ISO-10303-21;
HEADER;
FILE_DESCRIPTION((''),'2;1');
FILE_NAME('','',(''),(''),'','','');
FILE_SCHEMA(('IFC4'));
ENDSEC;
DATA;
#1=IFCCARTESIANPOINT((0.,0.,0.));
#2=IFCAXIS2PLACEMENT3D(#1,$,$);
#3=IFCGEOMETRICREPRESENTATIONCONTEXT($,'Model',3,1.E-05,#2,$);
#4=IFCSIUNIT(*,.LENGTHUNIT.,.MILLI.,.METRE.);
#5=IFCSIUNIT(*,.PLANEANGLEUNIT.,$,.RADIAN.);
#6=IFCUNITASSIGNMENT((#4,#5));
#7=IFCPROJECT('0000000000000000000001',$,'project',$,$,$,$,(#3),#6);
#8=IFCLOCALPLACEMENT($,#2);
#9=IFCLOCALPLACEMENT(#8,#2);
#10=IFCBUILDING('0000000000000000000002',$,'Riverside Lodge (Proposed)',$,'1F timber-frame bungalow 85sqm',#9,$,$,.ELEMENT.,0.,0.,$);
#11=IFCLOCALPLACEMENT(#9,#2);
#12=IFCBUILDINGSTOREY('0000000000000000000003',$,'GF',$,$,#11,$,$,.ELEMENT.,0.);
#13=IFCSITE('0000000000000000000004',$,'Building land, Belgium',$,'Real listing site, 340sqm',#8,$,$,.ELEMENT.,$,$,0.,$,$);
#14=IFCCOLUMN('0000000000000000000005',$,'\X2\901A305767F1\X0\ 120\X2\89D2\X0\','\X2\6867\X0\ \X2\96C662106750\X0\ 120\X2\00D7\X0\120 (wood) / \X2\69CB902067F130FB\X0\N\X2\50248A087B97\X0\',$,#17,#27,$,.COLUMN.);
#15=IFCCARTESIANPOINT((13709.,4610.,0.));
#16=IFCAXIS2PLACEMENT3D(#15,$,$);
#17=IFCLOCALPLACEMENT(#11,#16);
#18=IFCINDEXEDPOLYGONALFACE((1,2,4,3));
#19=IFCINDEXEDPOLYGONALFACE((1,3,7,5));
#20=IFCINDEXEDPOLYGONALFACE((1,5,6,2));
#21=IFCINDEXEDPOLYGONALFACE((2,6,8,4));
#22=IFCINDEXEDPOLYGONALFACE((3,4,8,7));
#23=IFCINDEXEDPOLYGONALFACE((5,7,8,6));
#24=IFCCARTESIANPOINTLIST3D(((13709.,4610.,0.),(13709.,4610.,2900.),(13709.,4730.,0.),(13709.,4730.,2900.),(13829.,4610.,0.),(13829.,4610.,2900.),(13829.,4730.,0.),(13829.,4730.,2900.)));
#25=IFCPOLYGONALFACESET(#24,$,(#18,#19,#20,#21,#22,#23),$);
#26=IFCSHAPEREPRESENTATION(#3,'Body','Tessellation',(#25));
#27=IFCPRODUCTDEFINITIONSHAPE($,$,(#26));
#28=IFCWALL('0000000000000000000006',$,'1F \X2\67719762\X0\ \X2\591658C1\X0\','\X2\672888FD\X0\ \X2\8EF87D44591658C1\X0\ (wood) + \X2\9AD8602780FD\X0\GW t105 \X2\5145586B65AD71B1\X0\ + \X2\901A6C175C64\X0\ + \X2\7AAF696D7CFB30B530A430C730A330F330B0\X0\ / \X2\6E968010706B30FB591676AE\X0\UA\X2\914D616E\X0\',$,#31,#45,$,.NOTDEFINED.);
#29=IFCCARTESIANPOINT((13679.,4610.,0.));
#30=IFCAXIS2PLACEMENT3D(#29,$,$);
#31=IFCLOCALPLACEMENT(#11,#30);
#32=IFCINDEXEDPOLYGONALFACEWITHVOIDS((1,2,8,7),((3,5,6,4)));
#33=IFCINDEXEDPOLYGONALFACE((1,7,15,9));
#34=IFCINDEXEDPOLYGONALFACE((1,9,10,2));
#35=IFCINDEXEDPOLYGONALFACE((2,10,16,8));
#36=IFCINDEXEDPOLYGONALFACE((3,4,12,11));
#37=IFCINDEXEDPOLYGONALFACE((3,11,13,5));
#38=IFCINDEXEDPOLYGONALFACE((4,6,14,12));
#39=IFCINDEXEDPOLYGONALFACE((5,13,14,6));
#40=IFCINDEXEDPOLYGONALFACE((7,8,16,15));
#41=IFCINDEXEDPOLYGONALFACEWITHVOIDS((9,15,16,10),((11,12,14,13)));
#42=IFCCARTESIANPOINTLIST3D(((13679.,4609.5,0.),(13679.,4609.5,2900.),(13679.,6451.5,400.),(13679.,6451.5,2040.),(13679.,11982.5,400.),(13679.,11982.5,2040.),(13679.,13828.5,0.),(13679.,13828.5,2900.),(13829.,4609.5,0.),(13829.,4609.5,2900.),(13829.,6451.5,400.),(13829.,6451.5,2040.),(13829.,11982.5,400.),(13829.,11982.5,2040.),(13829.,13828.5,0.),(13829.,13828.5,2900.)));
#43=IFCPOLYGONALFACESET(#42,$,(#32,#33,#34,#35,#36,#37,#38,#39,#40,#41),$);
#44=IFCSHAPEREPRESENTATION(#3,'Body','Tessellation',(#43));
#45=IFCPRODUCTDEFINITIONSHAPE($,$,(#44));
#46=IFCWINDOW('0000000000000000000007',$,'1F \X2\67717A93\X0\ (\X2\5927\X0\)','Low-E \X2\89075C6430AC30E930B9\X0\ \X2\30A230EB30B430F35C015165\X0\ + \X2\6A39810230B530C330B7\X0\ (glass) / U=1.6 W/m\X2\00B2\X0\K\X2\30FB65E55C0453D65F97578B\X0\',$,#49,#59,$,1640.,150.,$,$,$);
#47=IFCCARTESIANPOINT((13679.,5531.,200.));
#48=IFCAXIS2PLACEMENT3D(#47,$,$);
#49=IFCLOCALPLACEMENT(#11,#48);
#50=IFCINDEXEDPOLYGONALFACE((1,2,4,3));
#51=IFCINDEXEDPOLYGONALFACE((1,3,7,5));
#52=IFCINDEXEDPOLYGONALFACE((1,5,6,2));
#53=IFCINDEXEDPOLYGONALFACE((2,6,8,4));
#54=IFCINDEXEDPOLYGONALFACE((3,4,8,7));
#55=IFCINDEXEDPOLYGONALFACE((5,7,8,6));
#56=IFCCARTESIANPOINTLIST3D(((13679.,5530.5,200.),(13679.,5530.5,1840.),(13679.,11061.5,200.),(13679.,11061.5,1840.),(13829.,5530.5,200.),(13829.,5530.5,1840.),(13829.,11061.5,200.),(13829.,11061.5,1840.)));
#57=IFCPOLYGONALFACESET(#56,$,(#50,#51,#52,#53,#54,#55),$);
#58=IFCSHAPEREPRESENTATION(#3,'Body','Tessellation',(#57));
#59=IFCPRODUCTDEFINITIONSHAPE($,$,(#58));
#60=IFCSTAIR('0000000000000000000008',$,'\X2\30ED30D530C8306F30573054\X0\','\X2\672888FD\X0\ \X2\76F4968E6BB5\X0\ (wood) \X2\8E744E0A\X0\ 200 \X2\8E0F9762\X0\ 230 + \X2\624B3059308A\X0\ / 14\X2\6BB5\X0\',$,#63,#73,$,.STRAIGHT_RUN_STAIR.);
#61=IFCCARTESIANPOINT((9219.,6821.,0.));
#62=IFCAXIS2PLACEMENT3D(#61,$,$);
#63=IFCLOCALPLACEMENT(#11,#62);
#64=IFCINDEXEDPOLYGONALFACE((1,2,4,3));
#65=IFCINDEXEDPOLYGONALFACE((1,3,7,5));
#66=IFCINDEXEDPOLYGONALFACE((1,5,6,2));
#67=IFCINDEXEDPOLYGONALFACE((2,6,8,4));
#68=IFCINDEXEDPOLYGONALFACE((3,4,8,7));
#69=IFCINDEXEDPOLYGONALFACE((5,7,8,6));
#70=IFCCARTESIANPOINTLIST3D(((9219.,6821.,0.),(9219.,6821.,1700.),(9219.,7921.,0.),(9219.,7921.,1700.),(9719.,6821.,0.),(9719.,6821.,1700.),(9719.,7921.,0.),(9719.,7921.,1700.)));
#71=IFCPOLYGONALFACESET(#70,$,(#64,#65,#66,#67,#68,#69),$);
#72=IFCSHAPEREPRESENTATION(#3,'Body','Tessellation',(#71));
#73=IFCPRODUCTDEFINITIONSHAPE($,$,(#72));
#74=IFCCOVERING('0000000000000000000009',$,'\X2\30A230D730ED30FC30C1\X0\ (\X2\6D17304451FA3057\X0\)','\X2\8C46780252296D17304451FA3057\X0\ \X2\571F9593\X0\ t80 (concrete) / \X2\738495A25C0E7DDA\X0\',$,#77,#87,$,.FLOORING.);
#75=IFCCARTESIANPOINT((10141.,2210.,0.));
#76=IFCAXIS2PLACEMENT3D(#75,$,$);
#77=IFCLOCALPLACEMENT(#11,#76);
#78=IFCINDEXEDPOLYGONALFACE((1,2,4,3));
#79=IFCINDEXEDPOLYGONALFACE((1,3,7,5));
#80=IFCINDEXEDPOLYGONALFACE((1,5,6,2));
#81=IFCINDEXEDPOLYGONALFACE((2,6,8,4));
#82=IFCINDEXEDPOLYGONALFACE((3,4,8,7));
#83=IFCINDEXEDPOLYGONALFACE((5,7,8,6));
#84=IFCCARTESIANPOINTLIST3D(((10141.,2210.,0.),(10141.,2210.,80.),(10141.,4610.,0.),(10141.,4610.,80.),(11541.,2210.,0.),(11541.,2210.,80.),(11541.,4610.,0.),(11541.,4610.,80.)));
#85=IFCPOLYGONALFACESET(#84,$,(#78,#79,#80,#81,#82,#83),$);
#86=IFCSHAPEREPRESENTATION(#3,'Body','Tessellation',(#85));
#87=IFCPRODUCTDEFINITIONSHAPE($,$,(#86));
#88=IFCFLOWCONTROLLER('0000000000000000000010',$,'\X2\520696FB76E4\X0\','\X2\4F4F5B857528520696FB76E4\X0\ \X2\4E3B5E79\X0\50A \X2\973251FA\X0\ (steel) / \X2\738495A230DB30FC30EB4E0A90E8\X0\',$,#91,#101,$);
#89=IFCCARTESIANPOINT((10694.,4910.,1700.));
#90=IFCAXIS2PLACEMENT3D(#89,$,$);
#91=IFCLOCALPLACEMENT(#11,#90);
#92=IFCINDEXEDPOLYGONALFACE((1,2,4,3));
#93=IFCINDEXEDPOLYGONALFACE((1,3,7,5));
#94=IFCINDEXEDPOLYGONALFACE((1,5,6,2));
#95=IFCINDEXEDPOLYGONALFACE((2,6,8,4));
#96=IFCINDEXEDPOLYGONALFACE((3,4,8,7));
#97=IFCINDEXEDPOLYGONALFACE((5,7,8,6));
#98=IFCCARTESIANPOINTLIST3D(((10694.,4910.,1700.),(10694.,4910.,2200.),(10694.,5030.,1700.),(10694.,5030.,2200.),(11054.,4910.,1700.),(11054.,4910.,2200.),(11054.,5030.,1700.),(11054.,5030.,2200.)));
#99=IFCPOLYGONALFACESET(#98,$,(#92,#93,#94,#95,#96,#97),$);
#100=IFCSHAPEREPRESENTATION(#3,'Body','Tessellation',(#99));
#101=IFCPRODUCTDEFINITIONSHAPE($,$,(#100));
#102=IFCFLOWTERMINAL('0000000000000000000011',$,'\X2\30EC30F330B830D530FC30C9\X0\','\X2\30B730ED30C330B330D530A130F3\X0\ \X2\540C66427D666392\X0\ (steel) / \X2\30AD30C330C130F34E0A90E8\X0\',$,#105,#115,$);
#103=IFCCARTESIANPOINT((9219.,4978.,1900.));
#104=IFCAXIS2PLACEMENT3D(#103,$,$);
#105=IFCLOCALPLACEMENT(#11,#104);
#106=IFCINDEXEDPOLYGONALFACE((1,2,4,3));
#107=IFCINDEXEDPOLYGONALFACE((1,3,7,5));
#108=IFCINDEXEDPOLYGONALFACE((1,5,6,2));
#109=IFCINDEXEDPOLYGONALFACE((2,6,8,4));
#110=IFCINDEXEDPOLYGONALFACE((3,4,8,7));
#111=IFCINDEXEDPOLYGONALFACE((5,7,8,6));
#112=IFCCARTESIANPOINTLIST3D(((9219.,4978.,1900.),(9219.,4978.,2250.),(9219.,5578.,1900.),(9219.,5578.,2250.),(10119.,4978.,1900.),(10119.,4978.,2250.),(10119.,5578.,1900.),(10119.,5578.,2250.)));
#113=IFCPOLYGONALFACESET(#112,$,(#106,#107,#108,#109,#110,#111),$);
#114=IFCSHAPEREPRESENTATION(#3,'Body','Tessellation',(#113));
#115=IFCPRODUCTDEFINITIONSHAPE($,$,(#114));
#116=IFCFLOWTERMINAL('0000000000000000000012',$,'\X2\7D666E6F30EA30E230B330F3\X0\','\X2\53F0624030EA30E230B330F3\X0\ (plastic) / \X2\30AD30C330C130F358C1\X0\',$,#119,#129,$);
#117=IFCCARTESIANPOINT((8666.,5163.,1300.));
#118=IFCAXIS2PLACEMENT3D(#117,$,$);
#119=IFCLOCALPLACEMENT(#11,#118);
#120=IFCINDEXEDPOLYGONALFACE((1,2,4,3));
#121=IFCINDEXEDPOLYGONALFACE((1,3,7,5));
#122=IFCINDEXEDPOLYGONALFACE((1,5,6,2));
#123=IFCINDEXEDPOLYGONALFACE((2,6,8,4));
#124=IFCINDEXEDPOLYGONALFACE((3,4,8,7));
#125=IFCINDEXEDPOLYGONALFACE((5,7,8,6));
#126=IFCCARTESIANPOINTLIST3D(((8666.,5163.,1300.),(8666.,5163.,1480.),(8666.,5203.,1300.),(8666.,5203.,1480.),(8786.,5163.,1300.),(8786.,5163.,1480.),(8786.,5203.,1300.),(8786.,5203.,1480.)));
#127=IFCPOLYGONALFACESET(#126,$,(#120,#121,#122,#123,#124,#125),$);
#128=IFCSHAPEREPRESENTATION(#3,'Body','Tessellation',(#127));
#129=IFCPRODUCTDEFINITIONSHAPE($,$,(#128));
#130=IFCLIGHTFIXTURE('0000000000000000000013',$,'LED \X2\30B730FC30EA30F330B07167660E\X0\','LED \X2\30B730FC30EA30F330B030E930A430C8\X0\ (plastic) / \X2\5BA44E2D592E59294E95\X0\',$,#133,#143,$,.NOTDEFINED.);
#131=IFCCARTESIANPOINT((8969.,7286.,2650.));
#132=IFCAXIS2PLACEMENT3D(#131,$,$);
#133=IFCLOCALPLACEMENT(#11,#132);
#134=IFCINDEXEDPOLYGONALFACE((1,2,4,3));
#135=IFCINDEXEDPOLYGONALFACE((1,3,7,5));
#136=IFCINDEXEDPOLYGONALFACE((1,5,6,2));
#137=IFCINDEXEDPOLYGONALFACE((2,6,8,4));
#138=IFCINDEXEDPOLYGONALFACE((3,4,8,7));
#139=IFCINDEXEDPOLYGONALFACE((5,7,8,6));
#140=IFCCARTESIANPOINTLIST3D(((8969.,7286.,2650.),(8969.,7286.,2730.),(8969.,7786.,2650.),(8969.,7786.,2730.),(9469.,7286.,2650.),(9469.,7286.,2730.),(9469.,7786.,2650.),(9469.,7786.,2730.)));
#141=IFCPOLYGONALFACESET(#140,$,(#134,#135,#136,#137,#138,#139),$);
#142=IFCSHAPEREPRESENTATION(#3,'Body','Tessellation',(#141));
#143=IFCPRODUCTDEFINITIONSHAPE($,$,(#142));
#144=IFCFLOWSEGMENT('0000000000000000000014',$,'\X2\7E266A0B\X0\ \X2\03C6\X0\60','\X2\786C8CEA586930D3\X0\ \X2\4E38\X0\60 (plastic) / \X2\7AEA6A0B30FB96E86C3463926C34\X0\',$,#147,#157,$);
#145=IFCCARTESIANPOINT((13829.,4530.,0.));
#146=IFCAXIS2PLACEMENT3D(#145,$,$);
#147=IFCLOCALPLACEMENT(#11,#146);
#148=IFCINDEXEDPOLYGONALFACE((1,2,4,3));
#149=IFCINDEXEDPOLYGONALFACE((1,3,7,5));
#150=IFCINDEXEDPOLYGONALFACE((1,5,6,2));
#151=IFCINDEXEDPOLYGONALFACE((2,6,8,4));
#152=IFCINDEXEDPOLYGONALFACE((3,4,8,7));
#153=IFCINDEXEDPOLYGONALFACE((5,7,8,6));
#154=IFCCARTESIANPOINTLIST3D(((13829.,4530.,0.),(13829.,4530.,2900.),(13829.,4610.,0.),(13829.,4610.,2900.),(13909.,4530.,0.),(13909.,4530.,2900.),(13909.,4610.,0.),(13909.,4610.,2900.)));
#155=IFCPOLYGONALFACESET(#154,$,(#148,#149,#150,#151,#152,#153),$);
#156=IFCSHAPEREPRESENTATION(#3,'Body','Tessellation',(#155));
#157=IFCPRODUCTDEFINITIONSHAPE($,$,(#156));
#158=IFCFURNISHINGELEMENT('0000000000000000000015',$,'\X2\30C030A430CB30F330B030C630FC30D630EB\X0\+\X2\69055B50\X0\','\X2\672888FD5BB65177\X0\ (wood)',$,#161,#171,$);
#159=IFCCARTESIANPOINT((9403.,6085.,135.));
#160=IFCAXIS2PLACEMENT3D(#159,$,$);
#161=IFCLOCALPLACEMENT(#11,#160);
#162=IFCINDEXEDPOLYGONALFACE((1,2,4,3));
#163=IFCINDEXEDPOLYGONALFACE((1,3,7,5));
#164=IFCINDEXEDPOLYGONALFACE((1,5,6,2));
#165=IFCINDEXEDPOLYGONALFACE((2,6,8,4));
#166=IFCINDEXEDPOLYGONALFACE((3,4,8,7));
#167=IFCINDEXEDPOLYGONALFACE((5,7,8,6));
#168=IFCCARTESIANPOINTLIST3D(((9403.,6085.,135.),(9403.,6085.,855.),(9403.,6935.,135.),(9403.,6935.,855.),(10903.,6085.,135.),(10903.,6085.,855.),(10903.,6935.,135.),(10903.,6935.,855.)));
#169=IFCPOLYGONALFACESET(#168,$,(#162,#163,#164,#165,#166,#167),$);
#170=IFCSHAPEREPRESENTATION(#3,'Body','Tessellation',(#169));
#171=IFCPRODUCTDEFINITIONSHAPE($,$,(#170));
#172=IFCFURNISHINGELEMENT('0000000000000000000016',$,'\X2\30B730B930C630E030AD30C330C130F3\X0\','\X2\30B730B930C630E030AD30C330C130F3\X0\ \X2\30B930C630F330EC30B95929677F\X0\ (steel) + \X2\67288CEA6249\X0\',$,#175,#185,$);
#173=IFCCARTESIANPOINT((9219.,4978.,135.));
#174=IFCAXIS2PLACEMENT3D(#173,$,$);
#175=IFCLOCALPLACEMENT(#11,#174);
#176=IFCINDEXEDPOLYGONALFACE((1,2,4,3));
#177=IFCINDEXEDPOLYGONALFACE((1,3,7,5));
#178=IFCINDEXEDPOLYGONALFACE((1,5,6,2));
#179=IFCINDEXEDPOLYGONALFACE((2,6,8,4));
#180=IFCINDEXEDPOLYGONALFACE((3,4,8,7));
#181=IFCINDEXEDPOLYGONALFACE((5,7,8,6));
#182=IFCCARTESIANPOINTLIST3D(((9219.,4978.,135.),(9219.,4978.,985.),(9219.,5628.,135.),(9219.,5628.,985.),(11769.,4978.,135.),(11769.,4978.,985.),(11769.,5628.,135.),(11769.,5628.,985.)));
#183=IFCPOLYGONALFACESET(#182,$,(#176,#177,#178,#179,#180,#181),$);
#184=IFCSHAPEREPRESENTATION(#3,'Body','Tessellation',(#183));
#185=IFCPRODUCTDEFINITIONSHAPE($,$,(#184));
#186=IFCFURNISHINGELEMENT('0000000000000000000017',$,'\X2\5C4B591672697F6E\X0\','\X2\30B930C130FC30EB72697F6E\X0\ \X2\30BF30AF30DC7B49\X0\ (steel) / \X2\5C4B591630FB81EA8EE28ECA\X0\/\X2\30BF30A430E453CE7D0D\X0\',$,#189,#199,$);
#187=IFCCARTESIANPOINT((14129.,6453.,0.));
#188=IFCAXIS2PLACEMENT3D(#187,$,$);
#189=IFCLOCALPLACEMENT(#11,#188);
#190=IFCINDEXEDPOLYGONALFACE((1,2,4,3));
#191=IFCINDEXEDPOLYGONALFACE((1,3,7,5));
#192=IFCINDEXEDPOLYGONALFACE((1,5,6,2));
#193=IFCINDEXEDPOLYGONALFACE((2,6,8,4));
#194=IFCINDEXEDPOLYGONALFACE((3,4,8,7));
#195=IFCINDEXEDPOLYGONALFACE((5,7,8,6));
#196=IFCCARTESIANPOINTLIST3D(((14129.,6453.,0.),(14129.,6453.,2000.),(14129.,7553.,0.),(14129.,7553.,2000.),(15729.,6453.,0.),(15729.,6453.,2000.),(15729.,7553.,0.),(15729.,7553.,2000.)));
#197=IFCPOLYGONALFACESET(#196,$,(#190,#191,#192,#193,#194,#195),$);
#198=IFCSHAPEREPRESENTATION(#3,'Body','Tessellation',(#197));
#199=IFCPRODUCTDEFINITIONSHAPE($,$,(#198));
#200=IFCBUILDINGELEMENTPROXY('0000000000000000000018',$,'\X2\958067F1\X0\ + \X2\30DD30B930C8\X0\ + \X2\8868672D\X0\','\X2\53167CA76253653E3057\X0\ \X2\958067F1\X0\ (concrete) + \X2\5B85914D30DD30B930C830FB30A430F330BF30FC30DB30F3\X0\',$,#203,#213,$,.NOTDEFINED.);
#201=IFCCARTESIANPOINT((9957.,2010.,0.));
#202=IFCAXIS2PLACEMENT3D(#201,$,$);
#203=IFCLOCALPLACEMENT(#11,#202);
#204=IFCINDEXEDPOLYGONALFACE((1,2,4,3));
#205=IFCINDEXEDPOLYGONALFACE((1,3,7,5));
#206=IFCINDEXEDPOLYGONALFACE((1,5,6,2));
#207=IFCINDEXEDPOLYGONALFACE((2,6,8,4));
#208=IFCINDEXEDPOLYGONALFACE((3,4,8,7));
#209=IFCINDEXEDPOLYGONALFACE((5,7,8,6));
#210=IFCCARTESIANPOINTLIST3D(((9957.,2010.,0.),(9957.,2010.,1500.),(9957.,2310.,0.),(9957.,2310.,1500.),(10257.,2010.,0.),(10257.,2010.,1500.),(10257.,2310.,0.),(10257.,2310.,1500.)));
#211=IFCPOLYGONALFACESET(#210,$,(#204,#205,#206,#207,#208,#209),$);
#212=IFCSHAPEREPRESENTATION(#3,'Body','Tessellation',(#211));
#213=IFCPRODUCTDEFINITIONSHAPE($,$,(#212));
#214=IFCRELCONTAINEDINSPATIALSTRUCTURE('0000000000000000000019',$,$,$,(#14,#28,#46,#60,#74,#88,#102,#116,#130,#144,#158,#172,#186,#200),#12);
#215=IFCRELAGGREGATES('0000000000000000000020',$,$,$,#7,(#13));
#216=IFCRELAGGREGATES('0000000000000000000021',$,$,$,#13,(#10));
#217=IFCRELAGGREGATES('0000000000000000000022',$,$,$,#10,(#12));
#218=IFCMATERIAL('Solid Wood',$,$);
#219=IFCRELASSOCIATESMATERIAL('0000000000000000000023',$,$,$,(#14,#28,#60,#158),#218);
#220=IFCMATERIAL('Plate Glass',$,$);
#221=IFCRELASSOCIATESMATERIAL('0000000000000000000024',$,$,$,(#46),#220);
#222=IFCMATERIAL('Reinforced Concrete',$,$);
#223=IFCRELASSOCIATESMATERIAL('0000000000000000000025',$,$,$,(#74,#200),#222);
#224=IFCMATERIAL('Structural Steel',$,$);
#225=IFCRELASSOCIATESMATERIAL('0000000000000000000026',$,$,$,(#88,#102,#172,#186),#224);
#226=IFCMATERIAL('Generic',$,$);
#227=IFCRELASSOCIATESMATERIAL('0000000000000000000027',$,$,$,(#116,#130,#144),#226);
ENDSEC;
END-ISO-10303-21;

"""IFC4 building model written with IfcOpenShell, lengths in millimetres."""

from ifc_helpers import new_model, si_unit, frame, frame_2d, origin, place, context, project, spatial, rectangle, extrude, material, element, fill, save


model = new_model("IFC4")

# Units and contexts
model_context = context("Model", 3, precision=1e-05, world=origin())
ifc_project = project(units=[si_unit("LENGTHUNIT", "METRE", prefix="MILLI"), si_unit("PLANEANGLEUNIT", "RADIAN")], contexts=[model_context])

# Site, building, storey
site_placement = place(None, origin())
site = spatial("IfcSite", under=ifc_project, at=site_placement, Name="Building land, Belgium", ObjectType="Real listing site, 340sqm", CompositionType="ELEMENT", RefElevation=0.0)
building_placement = place(site_placement, origin())
building = spatial("IfcBuilding", under=site, at=building_placement, Name="Riverside Lodge (Proposed)", ObjectType="1F timber-frame bungalow 85sqm", CompositionType="ELEMENT", ElevationOfRefHeight=0.0, ElevationOfTerrain=0.0)
storey_placement = place(building_placement, origin())
storey = spatial("IfcBuildingStorey", under=building, at=storey_placement, Name="GF", CompositionType="ELEMENT", Elevation=0.0)

# Column
ifc_material_1 = material(Name="Solid Wood")
column_1_placement = place(storey_placement, frame((13709.0, 4610.0, 0.0)))
element("IfcColumn", 1, at=column_1_placement, inside=storey, material=ifc_material_1, Name="通し柱 120角", Description="桧 集成材 120×120 (wood) / 構造柱・N値計算", PredefinedType="COLUMN", context=model_context, shape_type="SweptSolid", body=[
    extrude(rectangle(XDim=120.0, YDim=120.0, at=frame_2d((60.0, 60.0))), frame((13709.0, 4610.0, 0.0)), (0.0, 0.0, 1.0), 2900.0),
])

# Wall, opening, window
wall_1_placement = place(storey_placement, frame((13679.0, 4610.0, 0.0)))
wall_1 = element("IfcWall", 2, at=wall_1_placement, inside=storey, material=ifc_material_1, Name="1F 東面 外壁", Description="木製 軸組外壁 (wood) + 高性能GW t105 充填断熱 + 通気層 + 窯業系サイディング / 準耐火・外皮UA配慮", PredefinedType="NOTDEFINED", context=model_context, shape_type="SweptSolid", body=[
    extrude(rectangle(XDim=150.0, YDim=9219.0, at=frame_2d((75.0, 4609.0))), frame((13679.0, 4610.0, 0.0)), (0.0, 0.0, 1.0), 2900.0),
])
opening_placement = place(storey_placement, frame((13679.0, 5531.0, 200.0)))
opening = element("IfcOpeningElement", 3, at=opening_placement, cuts=wall_1, PredefinedType="NOTDEFINED", context=model_context, shape_type="SweptSolid", body=[
    extrude(rectangle(XDim=150.0, YDim=5531.0, at=frame_2d((75.0, 2765.0))), frame((13679.0, 5531.0, 200.0)), (0.0, 0.0, 1.0), 1640.0),
])
ifc_material_2 = material(Name="Plate Glass")
window_placement = place(storey_placement, frame((13679.0, 5531.0, 200.0)))
window = element("IfcWindow", 4, at=window_placement, inside=storey, material=ifc_material_2, Name="1F 東窓 (大)", Description="Low-E 複層ガラス アルゴン封入 + 樹脂サッシ (glass) / U=1.6 W/m²K・日射取得型", OverallHeight=1640.0, OverallWidth=150.0, context=model_context, shape_type="SweptSolid", body=[
    extrude(rectangle(XDim=150.0, YDim=5531.0, at=frame_2d((75.0, 2765.0))), frame((13679.0, 5531.0, 200.0)), (0.0, 0.0, 1.0), 1640.0),
])
fill(opening, window)

# Stair
stair_placement = place(storey_placement, frame((9219.0, 6821.0, 0.0)))
element("IfcStair", 5, at=stair_placement, inside=storey, material=ifc_material_1, Name="ロフトはしご", Description="木製 直階段 (wood) 蹴上 200 踏面 230 + 手すり / 14段", PredefinedType="STRAIGHT_RUN_STAIR", context=model_context, shape_type="SweptSolid", body=[
    extrude(rectangle(XDim=500.0, YDim=1100.0, at=frame_2d((250.0, 550.0))), frame((9219.0, 6821.0, 0.0)), (0.0, 0.0, 1.0), 1700.0),
])

# Covering
ifc_material_3 = material(Name="Reinforced Concrete")
covering_placement = place(storey_placement, frame((10141.0, 2210.0, 0.0)))
element("IfcCovering", 6, at=covering_placement, inside=storey, material=ifc_material_3, Name="アプローチ (洗い出し)", Description="豆砂利洗い出し 土間 t80 (concrete) / 玄関導線", PredefinedType="FLOORING", context=model_context, shape_type="SweptSolid", body=[
    extrude(rectangle(XDim=1400.0, YDim=2400.0, at=frame_2d((700.0, 1200.0))), frame((10141.0, 2210.0, 0.0)), (0.0, 0.0, 1.0), 80.0),
])

# Flow controller
ifc_material_4 = material(Name="Structural Steel")
flow_controller_placement = place(storey_placement, frame((10694.0, 4910.0, 1700.0)))
element("IfcFlowController", 7, at=flow_controller_placement, inside=storey, material=ifc_material_4, Name="分電盤", Description="住宅用分電盤 主幹50A 露出 (steel) / 玄関ホール上部", context=model_context, shape_type="SweptSolid", body=[
    extrude(rectangle(XDim=360.0, YDim=120.0, at=frame_2d((180.0, 60.0))), frame((10694.0, 4910.0, 1700.0)), (0.0, 0.0, 1.0), 500.0),
])

# Flow terminals
flow_terminal_1_placement = place(storey_placement, frame((9219.0, 4978.0, 1900.0)))
element("IfcFlowTerminal", 8, at=flow_terminal_1_placement, inside=storey, material=ifc_material_4, Name="レンジフード", Description="シロッコファン 同時給排 (steel) / キッチン上部", context=model_context, shape_type="SweptSolid", body=[
    extrude(rectangle(XDim=900.0, YDim=600.0, at=frame_2d((450.0, 300.0))), frame((9219.0, 4978.0, 1900.0)), (0.0, 0.0, 1.0), 350.0),
])
ifc_material_5 = material(Name="Generic")
flow_terminal_2_placement = place(storey_placement, frame((8666.0, 5163.0, 1300.0)))
element("IfcFlowTerminal", 9, at=flow_terminal_2_placement, inside=storey, material=ifc_material_5, Name="給湯リモコン", Description="台所リモコン (plastic) / キッチン壁", context=model_context, shape_type="SweptSolid", body=[
    extrude(rectangle(XDim=120.0, YDim=40.0, at=frame_2d((60.0, 20.0))), frame((8666.0, 5163.0, 1300.0)), (0.0, 0.0, 1.0), 180.0),
])

# Light fixture
light_fixture_placement = place(storey_placement, frame((8969.0, 7286.0, 2650.0)))
element("IfcLightFixture", 10, at=light_fixture_placement, inside=storey, material=ifc_material_5, Name="LED シーリング照明", Description="LED シーリングライト (plastic) / 室中央天井", PredefinedType="NOTDEFINED", context=model_context, shape_type="SweptSolid", body=[
    extrude(rectangle(XDim=500.0, YDim=500.0, at=frame_2d((250.0, 250.0))), frame((8969.0, 7286.0, 2650.0)), (0.0, 0.0, 1.0), 80.0),
])

# Flow segment
flow_segment_placement = place(storey_placement, frame((13829.0, 4530.0, 0.0)))
element("IfcFlowSegment", 11, at=flow_segment_placement, inside=storey, material=ifc_material_5, Name="縦樋 φ60", Description="硬質塩ビ 丸60 (plastic) / 竪樋・雨水排水", context=model_context, shape_type="SweptSolid", body=[
    extrude(rectangle(XDim=80.0, YDim=80.0, at=frame_2d((40.0, 40.0))), frame((13829.0, 4530.0, 0.0)), (0.0, 0.0, 1.0), 2900.0),
])

# Furnishing elements
furnishing_1_placement = place(storey_placement, frame((9403.0, 6085.0, 135.0)))
element("IfcFurnishingElement", 12, at=furnishing_1_placement, inside=storey, material=ifc_material_1, Name="ダイニングテーブル+椅子", Description="木製家具 (wood)", context=model_context, shape_type="SweptSolid", body=[
    extrude(rectangle(XDim=1500.0, YDim=850.0, at=frame_2d((750.0, 425.0))), frame((9403.0, 6085.0, 135.0)), (0.0, 0.0, 1.0), 720.0),
])
furnishing_2_placement = place(storey_placement, frame((9219.0, 4978.0, 135.0)))
element("IfcFurnishingElement", 13, at=furnishing_2_placement, inside=storey, material=ifc_material_4, Name="システムキッチン", Description="システムキッチン ステンレス天板 (steel) + 木質扉", context=model_context, shape_type="SweptSolid", body=[
    extrude(rectangle(XDim=2550.0, YDim=650.0, at=frame_2d((1275.0, 325.0))), frame((9219.0, 4978.0, 135.0)), (0.0, 0.0, 1.0), 850.0),
])
furnishing_3_placement = place(storey_placement, frame((14129.0, 6453.0, 0.0)))
element("IfcFurnishingElement", 14, at=furnishing_3_placement, inside=storey, material=ifc_material_4, Name="屋外物置", Description="スチール物置 タクボ等 (steel) / 屋外・自転車/タイヤ収納", context=model_context, shape_type="SweptSolid", body=[
    extrude(rectangle(XDim=1600.0, YDim=1100.0, at=frame_2d((800.0, 550.0))), frame((14129.0, 6453.0, 0.0)), (0.0, 0.0, 1.0), 2000.0),
])

# Building element proxy
proxy_placement = place(storey_placement, frame((9957.0, 2010.0, 0.0)))
element("IfcBuildingElementProxy", 15, at=proxy_placement, inside=storey, material=ifc_material_3, Name="門柱 + ポスト + 表札", Description="化粧打放し 門柱 (concrete) + 宅配ポスト・インターホン", PredefinedType="NOTDEFINED", context=model_context, shape_type="SweptSolid", body=[
    extrude(rectangle(XDim=300.0, YDim=300.0, at=frame_2d((150.0, 150.0))), frame((9957.0, 2010.0, 0.0)), (0.0, 0.0, 1.0), 1500.0),
])

save(model, "model.ifc")
